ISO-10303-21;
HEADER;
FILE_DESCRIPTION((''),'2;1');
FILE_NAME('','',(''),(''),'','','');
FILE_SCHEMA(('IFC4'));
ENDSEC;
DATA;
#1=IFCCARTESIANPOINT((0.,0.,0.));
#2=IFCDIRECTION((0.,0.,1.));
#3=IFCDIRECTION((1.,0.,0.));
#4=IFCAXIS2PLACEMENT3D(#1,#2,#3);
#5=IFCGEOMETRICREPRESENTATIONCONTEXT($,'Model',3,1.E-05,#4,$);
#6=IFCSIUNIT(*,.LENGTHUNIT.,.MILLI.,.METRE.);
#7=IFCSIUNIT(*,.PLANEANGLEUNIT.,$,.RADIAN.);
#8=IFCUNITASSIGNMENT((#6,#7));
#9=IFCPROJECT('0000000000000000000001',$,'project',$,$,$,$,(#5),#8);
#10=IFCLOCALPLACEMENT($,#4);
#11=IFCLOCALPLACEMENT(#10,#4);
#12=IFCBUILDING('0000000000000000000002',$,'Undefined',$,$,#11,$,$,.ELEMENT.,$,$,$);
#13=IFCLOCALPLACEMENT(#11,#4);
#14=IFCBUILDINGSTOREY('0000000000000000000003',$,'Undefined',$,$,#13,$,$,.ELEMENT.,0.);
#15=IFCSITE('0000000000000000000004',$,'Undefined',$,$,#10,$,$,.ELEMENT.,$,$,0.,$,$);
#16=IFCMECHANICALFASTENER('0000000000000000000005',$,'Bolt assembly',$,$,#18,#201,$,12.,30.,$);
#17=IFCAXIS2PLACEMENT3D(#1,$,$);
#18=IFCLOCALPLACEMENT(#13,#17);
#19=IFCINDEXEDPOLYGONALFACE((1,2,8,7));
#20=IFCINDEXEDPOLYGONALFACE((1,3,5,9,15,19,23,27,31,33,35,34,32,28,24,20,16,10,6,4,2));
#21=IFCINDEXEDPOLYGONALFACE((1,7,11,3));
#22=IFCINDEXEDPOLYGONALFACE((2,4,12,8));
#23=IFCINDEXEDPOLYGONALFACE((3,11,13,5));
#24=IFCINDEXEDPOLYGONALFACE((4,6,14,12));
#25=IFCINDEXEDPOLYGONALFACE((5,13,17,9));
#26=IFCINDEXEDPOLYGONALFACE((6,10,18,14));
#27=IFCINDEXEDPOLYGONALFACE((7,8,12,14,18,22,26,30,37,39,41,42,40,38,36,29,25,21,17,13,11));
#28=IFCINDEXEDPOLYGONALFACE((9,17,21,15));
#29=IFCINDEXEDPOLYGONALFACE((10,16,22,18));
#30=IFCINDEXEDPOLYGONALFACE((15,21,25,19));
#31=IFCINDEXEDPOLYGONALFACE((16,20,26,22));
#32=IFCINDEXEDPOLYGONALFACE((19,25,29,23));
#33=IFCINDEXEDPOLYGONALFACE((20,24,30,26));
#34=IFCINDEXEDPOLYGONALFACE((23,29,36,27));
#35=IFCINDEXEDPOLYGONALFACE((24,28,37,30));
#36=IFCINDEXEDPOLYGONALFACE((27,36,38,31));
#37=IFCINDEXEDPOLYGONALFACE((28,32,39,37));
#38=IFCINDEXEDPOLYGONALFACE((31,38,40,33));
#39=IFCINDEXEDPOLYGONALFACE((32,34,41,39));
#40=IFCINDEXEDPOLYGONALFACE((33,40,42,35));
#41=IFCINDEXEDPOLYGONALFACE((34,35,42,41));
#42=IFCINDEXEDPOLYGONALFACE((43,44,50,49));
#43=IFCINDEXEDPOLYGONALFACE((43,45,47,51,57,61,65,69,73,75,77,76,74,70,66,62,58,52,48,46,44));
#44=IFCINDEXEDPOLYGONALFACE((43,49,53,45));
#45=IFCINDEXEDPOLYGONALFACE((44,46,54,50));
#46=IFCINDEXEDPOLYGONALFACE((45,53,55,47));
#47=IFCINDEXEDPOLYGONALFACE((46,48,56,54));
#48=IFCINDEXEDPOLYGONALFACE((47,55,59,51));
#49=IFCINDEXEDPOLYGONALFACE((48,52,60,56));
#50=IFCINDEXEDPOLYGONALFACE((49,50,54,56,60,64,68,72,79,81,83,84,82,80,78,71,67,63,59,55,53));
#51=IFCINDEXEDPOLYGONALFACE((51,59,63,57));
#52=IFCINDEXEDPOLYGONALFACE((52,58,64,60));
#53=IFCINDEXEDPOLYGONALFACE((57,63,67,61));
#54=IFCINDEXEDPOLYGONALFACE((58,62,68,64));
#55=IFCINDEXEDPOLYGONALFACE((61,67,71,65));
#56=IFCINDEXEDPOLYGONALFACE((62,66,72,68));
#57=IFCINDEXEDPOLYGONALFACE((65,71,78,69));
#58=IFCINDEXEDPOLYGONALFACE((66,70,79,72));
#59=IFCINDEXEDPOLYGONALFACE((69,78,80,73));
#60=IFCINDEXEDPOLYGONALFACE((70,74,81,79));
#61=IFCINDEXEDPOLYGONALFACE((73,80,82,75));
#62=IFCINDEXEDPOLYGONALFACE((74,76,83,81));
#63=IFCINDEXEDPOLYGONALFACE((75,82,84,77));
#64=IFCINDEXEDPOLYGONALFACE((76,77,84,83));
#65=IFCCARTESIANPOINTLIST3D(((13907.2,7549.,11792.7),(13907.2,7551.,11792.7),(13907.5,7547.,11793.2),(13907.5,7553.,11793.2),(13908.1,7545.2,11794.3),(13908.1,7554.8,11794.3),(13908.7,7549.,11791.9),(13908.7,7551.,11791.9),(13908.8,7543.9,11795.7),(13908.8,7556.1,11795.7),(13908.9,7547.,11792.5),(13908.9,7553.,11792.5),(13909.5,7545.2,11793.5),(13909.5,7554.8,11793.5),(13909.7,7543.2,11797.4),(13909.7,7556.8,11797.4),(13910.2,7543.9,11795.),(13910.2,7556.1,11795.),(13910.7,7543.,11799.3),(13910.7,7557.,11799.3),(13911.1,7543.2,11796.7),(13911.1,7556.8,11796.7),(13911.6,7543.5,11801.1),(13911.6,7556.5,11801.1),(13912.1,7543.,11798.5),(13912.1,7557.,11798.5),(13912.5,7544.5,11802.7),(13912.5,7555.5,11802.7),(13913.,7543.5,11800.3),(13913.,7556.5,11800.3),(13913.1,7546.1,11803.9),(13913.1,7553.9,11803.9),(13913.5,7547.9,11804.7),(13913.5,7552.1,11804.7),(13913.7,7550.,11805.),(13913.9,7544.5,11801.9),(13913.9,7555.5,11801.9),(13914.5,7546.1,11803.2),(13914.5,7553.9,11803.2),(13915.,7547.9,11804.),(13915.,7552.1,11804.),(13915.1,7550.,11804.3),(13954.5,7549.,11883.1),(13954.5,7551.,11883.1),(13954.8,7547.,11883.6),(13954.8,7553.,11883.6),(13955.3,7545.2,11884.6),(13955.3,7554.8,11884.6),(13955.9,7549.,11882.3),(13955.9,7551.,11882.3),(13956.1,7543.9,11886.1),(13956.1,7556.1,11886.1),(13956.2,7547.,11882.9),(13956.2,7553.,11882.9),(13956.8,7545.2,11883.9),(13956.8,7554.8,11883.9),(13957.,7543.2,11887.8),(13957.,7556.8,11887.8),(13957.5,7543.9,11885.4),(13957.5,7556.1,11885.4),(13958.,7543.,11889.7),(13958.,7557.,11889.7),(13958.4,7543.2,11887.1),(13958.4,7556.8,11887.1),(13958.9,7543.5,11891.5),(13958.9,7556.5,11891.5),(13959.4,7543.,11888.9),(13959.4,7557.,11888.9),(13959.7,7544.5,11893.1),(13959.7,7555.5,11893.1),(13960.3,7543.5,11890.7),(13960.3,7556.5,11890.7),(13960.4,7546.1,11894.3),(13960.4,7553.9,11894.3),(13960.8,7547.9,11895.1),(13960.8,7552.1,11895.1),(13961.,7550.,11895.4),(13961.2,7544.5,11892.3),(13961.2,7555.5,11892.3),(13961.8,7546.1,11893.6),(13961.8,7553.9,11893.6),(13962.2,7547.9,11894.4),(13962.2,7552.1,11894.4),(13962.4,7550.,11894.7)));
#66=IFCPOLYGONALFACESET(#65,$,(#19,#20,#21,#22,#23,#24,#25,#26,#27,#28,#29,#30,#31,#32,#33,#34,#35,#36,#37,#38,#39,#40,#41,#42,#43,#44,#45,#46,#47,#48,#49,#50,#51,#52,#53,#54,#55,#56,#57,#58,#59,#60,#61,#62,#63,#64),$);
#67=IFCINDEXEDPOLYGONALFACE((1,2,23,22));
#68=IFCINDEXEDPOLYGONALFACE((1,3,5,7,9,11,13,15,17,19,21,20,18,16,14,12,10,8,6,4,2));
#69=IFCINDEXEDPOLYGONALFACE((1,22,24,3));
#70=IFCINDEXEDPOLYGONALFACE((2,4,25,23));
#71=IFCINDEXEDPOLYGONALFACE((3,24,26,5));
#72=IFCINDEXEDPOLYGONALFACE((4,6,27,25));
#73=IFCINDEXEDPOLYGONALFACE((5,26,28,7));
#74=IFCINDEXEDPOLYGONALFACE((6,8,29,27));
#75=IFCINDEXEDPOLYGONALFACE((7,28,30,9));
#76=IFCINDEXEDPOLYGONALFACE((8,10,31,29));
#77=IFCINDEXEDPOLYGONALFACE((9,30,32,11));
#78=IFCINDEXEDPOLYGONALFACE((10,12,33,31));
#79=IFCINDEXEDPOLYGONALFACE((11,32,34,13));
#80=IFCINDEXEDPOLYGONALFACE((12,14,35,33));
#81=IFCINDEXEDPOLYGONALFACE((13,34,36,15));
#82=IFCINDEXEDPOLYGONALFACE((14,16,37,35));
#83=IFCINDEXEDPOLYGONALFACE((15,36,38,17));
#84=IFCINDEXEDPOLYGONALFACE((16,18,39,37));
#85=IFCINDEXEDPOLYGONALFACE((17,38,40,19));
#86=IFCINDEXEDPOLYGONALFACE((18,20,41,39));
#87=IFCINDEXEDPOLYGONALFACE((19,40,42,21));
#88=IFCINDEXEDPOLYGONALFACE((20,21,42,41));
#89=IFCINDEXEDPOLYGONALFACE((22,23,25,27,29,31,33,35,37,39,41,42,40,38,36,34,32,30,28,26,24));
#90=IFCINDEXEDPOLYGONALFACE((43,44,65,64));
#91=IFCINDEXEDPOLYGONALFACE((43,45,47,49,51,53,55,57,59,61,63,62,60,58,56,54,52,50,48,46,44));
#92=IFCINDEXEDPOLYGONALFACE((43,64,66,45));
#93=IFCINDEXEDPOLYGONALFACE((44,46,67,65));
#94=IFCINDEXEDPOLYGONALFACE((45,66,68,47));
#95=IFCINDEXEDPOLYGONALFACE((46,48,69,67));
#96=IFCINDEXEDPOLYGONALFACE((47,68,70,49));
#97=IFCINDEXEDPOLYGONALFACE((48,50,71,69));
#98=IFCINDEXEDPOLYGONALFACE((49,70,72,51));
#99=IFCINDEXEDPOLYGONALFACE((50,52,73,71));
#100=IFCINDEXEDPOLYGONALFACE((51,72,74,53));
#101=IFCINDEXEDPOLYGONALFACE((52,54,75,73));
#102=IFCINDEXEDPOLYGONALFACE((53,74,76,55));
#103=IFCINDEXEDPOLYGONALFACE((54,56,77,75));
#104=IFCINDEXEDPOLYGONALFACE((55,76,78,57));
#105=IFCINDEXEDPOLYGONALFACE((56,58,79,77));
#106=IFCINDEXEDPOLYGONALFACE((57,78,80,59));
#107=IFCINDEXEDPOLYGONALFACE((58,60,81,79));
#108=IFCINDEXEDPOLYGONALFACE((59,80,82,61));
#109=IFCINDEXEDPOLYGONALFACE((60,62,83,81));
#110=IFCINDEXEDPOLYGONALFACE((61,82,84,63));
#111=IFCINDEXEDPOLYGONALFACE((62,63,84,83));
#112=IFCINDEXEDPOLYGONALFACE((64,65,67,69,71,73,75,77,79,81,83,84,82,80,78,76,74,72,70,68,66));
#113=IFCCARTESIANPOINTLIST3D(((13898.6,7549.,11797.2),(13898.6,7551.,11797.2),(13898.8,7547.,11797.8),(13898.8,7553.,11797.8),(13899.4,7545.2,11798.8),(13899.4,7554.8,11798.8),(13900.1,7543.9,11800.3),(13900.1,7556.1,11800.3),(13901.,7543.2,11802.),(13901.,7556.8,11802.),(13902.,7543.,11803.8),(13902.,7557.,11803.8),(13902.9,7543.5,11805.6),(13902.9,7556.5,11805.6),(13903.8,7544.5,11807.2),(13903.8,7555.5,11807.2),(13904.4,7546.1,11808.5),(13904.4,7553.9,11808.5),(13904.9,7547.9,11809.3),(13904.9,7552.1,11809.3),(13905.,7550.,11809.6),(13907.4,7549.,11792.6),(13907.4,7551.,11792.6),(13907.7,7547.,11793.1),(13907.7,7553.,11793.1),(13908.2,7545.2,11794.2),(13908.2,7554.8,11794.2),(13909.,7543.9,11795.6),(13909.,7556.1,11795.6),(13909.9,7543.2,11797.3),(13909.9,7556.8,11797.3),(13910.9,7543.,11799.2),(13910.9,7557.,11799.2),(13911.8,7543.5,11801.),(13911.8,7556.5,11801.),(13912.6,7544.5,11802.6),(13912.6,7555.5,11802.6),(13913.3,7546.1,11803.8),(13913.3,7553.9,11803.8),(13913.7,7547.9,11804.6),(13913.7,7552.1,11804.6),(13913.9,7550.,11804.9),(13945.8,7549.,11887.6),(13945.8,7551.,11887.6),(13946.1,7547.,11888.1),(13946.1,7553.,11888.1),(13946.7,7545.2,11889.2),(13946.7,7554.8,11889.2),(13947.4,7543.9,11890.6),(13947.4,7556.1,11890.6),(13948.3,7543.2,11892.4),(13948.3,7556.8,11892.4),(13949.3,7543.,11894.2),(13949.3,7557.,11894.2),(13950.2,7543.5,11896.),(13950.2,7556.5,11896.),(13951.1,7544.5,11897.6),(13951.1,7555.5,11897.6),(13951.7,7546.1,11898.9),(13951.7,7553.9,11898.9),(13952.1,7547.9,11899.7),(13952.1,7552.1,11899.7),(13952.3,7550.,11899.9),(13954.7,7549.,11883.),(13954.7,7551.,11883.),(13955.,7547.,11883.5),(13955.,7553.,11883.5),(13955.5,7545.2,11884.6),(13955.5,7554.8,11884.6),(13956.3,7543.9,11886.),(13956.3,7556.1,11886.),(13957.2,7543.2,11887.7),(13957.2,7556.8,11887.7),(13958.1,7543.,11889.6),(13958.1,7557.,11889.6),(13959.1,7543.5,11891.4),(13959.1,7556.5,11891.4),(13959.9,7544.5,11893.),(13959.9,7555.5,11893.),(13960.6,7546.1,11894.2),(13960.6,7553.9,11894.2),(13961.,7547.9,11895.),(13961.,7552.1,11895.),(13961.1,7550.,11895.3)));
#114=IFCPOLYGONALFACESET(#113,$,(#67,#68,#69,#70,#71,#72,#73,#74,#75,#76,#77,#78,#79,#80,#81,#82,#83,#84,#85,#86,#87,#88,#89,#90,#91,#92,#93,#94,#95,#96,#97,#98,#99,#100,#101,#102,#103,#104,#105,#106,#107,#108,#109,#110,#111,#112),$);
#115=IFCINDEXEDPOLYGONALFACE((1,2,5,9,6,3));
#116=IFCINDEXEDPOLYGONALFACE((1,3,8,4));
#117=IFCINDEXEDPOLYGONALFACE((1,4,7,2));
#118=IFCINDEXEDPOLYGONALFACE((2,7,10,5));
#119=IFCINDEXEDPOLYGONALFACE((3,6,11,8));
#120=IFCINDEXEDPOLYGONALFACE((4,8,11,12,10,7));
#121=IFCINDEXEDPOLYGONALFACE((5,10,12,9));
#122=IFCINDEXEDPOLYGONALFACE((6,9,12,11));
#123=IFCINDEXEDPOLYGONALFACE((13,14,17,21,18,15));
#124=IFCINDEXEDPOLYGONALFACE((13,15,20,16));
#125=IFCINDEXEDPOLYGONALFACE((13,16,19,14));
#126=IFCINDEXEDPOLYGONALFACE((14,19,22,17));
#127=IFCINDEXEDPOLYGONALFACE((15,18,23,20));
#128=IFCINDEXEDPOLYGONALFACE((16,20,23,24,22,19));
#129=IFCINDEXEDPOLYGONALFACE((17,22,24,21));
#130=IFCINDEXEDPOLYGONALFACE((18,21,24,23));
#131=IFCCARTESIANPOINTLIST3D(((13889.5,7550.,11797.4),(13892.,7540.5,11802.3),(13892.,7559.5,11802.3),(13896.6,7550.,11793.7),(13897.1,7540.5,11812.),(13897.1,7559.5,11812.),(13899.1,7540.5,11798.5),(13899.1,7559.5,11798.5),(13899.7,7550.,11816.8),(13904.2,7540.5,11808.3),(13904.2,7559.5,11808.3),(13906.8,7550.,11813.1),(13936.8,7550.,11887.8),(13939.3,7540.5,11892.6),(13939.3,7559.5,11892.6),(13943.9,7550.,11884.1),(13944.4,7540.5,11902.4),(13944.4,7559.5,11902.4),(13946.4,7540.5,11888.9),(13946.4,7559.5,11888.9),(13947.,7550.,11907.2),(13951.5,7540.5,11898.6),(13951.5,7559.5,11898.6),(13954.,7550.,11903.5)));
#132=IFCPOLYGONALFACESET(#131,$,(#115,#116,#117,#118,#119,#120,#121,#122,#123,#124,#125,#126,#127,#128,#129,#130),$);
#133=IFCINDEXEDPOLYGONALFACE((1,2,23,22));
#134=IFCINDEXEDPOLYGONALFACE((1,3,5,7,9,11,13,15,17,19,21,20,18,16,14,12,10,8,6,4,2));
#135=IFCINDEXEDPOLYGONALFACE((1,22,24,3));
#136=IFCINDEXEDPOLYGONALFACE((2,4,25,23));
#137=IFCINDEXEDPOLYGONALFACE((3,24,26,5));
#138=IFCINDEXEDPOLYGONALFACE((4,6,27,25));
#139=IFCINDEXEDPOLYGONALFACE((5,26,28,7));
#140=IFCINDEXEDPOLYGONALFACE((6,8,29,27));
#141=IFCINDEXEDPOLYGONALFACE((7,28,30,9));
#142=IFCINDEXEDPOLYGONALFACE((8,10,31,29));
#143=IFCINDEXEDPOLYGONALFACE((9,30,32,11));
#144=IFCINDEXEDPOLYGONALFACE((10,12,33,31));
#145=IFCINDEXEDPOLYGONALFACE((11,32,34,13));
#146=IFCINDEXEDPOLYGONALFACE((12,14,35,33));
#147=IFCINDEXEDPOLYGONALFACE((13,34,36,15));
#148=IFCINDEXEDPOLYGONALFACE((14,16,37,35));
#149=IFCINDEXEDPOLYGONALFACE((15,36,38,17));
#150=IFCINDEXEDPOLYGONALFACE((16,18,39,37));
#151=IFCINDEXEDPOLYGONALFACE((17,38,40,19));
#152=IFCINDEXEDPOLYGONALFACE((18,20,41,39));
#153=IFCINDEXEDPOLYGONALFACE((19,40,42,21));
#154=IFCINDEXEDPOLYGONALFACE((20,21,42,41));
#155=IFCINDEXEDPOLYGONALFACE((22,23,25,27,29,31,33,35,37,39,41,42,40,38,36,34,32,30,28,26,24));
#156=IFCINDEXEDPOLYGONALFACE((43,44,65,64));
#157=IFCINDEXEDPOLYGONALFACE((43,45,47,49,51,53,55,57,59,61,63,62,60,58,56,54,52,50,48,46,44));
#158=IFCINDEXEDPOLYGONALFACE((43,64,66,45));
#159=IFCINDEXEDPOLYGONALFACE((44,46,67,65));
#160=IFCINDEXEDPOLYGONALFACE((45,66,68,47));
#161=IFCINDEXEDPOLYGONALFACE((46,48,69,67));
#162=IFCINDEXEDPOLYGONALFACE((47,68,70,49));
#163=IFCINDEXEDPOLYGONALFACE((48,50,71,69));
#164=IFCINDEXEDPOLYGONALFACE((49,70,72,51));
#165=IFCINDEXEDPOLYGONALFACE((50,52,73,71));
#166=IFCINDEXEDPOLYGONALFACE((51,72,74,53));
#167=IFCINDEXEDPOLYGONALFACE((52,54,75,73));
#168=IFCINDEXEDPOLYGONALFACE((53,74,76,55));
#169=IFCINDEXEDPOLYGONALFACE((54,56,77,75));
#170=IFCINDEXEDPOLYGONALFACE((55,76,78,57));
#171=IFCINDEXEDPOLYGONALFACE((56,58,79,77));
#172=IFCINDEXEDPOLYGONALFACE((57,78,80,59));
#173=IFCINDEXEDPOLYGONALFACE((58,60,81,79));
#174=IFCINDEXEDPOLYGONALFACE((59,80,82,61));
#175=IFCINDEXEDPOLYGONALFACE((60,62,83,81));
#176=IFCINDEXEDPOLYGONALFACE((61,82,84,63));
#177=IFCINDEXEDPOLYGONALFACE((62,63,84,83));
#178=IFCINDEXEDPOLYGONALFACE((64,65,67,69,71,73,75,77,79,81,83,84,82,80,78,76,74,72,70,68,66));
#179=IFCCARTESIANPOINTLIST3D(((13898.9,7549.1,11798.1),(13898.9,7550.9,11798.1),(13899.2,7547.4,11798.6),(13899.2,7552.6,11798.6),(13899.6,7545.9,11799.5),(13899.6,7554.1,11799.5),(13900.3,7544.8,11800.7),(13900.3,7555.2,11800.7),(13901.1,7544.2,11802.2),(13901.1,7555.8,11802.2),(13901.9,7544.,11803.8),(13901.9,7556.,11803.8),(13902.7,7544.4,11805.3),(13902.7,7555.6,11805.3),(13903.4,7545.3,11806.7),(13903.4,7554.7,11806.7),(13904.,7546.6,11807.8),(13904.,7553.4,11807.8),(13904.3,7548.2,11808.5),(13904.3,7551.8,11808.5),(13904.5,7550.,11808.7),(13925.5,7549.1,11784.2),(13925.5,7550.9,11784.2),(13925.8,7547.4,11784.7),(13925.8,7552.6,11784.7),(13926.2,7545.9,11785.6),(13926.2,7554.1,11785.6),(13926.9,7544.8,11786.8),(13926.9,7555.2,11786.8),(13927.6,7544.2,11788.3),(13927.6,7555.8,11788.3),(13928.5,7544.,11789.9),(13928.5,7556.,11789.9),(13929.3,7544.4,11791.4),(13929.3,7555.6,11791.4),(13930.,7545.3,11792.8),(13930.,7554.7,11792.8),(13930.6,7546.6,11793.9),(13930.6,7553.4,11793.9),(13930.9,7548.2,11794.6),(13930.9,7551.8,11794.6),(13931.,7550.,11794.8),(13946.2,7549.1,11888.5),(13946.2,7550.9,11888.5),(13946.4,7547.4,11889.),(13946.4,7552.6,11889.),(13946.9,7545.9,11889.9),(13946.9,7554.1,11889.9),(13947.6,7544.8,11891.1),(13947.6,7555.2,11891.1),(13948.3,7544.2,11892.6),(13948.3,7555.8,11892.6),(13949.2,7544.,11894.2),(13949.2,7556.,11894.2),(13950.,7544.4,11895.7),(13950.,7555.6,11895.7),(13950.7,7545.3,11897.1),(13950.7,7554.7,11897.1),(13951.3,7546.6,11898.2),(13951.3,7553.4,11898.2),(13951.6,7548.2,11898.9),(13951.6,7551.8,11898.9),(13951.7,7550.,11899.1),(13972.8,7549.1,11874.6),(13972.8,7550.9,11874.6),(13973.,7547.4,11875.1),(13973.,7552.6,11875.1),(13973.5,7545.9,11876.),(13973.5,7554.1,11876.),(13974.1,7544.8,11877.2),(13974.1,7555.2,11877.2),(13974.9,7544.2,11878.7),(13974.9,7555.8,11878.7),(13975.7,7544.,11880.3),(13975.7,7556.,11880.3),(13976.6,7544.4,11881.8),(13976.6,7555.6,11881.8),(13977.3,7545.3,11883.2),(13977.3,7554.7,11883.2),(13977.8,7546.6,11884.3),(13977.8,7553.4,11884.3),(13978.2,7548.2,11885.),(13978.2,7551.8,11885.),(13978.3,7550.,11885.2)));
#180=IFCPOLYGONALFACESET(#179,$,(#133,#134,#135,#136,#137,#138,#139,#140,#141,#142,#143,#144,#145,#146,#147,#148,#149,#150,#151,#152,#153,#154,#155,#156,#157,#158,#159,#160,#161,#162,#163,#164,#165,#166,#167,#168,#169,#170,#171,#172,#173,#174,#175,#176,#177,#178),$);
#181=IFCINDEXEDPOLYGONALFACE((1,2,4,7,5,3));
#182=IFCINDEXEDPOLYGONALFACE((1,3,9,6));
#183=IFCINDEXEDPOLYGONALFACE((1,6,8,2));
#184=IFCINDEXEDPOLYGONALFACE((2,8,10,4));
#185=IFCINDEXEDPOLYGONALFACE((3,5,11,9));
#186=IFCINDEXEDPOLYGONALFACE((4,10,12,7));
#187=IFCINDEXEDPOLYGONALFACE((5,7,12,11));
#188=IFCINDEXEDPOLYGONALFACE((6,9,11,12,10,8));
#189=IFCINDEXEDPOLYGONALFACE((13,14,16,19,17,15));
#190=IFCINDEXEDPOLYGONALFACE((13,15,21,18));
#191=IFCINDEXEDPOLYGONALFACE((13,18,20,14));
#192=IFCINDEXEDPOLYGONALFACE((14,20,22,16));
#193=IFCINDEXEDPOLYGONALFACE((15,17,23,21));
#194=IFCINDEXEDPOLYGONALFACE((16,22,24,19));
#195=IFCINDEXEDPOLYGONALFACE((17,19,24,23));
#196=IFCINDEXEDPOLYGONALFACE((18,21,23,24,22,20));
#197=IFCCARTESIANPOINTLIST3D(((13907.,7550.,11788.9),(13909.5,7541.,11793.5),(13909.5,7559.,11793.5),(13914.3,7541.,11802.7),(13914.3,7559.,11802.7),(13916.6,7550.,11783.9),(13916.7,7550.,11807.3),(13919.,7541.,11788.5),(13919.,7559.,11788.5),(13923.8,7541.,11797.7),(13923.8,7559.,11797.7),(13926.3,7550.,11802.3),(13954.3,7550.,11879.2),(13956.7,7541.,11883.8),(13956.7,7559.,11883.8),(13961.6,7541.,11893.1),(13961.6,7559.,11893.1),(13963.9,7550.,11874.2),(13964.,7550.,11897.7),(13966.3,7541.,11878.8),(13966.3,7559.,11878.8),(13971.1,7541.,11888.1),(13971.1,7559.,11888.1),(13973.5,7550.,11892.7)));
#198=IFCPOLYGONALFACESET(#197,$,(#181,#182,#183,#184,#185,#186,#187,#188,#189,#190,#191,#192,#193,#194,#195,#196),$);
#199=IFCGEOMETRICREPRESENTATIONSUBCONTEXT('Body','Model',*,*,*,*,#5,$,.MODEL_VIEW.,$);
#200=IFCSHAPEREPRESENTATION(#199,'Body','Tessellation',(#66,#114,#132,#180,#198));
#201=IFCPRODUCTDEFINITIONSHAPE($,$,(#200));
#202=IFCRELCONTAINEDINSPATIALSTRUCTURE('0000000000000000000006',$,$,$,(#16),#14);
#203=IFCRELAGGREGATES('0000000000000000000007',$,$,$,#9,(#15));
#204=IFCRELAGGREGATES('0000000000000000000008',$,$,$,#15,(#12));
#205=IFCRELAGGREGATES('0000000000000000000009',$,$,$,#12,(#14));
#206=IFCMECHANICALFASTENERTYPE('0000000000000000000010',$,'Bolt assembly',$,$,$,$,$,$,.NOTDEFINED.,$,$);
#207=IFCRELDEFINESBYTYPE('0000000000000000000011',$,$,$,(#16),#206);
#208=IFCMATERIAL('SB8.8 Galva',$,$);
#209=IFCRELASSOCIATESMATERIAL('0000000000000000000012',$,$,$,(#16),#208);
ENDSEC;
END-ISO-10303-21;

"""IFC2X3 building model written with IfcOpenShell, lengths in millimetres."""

from ifc_helpers import new_model, si_unit, frame, origin_with_axes, origin_2d_with_axis, place, context, subcontext, project, spatial, polyline, circle, outline, extrude, source, transform, mapped, material, type_object, element, save


model = new_model("IFC2X3")

# Units and contexts
model_context = context("Model", 3, precision=1e-05, world=origin_with_axes())
body_context = subcontext(model_context, "Body", "Model", "MODEL_VIEW")
ifc_project = project(units=[si_unit("LENGTHUNIT", "METRE", prefix="MILLI"), si_unit("PLANEANGLEUNIT", "RADIAN")], contexts=[model_context])

# Site, building, storey
site_placement = place(None, origin_with_axes())
site = spatial("IfcSite", under=ifc_project, at=site_placement, Name="Undefined", CompositionType="ELEMENT", RefElevation=0.0)
building_placement = place(site_placement, origin_with_axes())
building = spatial("IfcBuilding", under=site, at=building_placement, Name="Undefined", CompositionType="ELEMENT")
storey_placement = place(building_placement, origin_with_axes())
storey = spatial("IfcBuildingStorey", under=building, at=storey_placement, Name="Undefined", CompositionType="ELEMENT", Elevation=0.0)

# Mechanical fastener
ifc_material_1 = material(Name="SB8.8 Galva")
mechanical_fastener_type = type_object("IfcMechanicalFastenerType", Name="Bolt assembly")
shared_shape_1 = source(origin_with_axes(), body_context, "Body", "SweptSolid", [
    extrude(circle(Radius=7.0, at=origin_2d_with_axis()), frame((0.0, -0.1, 0.0), z_axis=(0.0, 1.0, 0.0), x_axis=(1.0, 0.0, 0.0)), (0.0, 0.0, 1.0), 1.6),
    extrude(circle(Radius=7.0, at=origin_2d_with_axis()), frame((0.0, -9.9, 0.0), z_axis=(0.0, 1.0, 0.0), x_axis=(1.0, 0.0, 0.0)), (0.0, 0.0, 1.0), 10.0),
    extrude(outline(polyline([(11.0, 0.0), (5.5, 9.5), (-5.5, 9.5), (-11.0, 0.0), (-5.5, -9.5), (5.5, -9.5), (11.0, 0.0)])), frame((0.0, -18.0, 0.0), z_axis=(0.0, 1.0, 0.0), x_axis=(1.0, 0.0, 0.0)), (0.0, 0.0, 1.0), 8.0),
    extrude(circle(Radius=6.0, at=origin_2d_with_axis()), frame((0.0, -10.0, 0.0), z_axis=(0.0, 1.0, 0.0), x_axis=(1.0, 0.0, 0.0)), (0.0, 0.0, 1.0), 30.0),
    extrude(outline(polyline([(10.4, 0.0), (5.2, 9.0), (-5.2, 9.0), (-10.4, 0.0), (-5.2, -9.0), (5.2, -9.0), (10.4, 0.0)])), frame((0.0, 1.5, 0.0), z_axis=(0.0, 1.0, 0.0), x_axis=(1.0, 0.0, 0.0)), (0.0, 0.0, 1.0), 10.8),
])
for number, where, z_axis, x_axis, name in (
    (1, (13910.5, 7550.0, 11798.8), (0.0, 1.0, 0.0), (0.463529, 0.0, 0.886082), "Bolt assembly"),
):
    element("IfcMechanicalFastener", number, at=place(storey_placement, frame(where, z_axis=z_axis, x_axis=x_axis)), inside=storey, type_object=mechanical_fastener_type, material=ifc_material_1, Name=name, NominalDiameter=12.0, NominalLength=30.0, context=body_context, shape_type="MappedRepresentation", body=[
        mapped(shared_shape_1, transform((0.0, 0.0, 0.0))),
        mapped(shared_shape_1, transform((102.0, 0.0, 0.0))),
    ])

save(model, "model.ifc")
